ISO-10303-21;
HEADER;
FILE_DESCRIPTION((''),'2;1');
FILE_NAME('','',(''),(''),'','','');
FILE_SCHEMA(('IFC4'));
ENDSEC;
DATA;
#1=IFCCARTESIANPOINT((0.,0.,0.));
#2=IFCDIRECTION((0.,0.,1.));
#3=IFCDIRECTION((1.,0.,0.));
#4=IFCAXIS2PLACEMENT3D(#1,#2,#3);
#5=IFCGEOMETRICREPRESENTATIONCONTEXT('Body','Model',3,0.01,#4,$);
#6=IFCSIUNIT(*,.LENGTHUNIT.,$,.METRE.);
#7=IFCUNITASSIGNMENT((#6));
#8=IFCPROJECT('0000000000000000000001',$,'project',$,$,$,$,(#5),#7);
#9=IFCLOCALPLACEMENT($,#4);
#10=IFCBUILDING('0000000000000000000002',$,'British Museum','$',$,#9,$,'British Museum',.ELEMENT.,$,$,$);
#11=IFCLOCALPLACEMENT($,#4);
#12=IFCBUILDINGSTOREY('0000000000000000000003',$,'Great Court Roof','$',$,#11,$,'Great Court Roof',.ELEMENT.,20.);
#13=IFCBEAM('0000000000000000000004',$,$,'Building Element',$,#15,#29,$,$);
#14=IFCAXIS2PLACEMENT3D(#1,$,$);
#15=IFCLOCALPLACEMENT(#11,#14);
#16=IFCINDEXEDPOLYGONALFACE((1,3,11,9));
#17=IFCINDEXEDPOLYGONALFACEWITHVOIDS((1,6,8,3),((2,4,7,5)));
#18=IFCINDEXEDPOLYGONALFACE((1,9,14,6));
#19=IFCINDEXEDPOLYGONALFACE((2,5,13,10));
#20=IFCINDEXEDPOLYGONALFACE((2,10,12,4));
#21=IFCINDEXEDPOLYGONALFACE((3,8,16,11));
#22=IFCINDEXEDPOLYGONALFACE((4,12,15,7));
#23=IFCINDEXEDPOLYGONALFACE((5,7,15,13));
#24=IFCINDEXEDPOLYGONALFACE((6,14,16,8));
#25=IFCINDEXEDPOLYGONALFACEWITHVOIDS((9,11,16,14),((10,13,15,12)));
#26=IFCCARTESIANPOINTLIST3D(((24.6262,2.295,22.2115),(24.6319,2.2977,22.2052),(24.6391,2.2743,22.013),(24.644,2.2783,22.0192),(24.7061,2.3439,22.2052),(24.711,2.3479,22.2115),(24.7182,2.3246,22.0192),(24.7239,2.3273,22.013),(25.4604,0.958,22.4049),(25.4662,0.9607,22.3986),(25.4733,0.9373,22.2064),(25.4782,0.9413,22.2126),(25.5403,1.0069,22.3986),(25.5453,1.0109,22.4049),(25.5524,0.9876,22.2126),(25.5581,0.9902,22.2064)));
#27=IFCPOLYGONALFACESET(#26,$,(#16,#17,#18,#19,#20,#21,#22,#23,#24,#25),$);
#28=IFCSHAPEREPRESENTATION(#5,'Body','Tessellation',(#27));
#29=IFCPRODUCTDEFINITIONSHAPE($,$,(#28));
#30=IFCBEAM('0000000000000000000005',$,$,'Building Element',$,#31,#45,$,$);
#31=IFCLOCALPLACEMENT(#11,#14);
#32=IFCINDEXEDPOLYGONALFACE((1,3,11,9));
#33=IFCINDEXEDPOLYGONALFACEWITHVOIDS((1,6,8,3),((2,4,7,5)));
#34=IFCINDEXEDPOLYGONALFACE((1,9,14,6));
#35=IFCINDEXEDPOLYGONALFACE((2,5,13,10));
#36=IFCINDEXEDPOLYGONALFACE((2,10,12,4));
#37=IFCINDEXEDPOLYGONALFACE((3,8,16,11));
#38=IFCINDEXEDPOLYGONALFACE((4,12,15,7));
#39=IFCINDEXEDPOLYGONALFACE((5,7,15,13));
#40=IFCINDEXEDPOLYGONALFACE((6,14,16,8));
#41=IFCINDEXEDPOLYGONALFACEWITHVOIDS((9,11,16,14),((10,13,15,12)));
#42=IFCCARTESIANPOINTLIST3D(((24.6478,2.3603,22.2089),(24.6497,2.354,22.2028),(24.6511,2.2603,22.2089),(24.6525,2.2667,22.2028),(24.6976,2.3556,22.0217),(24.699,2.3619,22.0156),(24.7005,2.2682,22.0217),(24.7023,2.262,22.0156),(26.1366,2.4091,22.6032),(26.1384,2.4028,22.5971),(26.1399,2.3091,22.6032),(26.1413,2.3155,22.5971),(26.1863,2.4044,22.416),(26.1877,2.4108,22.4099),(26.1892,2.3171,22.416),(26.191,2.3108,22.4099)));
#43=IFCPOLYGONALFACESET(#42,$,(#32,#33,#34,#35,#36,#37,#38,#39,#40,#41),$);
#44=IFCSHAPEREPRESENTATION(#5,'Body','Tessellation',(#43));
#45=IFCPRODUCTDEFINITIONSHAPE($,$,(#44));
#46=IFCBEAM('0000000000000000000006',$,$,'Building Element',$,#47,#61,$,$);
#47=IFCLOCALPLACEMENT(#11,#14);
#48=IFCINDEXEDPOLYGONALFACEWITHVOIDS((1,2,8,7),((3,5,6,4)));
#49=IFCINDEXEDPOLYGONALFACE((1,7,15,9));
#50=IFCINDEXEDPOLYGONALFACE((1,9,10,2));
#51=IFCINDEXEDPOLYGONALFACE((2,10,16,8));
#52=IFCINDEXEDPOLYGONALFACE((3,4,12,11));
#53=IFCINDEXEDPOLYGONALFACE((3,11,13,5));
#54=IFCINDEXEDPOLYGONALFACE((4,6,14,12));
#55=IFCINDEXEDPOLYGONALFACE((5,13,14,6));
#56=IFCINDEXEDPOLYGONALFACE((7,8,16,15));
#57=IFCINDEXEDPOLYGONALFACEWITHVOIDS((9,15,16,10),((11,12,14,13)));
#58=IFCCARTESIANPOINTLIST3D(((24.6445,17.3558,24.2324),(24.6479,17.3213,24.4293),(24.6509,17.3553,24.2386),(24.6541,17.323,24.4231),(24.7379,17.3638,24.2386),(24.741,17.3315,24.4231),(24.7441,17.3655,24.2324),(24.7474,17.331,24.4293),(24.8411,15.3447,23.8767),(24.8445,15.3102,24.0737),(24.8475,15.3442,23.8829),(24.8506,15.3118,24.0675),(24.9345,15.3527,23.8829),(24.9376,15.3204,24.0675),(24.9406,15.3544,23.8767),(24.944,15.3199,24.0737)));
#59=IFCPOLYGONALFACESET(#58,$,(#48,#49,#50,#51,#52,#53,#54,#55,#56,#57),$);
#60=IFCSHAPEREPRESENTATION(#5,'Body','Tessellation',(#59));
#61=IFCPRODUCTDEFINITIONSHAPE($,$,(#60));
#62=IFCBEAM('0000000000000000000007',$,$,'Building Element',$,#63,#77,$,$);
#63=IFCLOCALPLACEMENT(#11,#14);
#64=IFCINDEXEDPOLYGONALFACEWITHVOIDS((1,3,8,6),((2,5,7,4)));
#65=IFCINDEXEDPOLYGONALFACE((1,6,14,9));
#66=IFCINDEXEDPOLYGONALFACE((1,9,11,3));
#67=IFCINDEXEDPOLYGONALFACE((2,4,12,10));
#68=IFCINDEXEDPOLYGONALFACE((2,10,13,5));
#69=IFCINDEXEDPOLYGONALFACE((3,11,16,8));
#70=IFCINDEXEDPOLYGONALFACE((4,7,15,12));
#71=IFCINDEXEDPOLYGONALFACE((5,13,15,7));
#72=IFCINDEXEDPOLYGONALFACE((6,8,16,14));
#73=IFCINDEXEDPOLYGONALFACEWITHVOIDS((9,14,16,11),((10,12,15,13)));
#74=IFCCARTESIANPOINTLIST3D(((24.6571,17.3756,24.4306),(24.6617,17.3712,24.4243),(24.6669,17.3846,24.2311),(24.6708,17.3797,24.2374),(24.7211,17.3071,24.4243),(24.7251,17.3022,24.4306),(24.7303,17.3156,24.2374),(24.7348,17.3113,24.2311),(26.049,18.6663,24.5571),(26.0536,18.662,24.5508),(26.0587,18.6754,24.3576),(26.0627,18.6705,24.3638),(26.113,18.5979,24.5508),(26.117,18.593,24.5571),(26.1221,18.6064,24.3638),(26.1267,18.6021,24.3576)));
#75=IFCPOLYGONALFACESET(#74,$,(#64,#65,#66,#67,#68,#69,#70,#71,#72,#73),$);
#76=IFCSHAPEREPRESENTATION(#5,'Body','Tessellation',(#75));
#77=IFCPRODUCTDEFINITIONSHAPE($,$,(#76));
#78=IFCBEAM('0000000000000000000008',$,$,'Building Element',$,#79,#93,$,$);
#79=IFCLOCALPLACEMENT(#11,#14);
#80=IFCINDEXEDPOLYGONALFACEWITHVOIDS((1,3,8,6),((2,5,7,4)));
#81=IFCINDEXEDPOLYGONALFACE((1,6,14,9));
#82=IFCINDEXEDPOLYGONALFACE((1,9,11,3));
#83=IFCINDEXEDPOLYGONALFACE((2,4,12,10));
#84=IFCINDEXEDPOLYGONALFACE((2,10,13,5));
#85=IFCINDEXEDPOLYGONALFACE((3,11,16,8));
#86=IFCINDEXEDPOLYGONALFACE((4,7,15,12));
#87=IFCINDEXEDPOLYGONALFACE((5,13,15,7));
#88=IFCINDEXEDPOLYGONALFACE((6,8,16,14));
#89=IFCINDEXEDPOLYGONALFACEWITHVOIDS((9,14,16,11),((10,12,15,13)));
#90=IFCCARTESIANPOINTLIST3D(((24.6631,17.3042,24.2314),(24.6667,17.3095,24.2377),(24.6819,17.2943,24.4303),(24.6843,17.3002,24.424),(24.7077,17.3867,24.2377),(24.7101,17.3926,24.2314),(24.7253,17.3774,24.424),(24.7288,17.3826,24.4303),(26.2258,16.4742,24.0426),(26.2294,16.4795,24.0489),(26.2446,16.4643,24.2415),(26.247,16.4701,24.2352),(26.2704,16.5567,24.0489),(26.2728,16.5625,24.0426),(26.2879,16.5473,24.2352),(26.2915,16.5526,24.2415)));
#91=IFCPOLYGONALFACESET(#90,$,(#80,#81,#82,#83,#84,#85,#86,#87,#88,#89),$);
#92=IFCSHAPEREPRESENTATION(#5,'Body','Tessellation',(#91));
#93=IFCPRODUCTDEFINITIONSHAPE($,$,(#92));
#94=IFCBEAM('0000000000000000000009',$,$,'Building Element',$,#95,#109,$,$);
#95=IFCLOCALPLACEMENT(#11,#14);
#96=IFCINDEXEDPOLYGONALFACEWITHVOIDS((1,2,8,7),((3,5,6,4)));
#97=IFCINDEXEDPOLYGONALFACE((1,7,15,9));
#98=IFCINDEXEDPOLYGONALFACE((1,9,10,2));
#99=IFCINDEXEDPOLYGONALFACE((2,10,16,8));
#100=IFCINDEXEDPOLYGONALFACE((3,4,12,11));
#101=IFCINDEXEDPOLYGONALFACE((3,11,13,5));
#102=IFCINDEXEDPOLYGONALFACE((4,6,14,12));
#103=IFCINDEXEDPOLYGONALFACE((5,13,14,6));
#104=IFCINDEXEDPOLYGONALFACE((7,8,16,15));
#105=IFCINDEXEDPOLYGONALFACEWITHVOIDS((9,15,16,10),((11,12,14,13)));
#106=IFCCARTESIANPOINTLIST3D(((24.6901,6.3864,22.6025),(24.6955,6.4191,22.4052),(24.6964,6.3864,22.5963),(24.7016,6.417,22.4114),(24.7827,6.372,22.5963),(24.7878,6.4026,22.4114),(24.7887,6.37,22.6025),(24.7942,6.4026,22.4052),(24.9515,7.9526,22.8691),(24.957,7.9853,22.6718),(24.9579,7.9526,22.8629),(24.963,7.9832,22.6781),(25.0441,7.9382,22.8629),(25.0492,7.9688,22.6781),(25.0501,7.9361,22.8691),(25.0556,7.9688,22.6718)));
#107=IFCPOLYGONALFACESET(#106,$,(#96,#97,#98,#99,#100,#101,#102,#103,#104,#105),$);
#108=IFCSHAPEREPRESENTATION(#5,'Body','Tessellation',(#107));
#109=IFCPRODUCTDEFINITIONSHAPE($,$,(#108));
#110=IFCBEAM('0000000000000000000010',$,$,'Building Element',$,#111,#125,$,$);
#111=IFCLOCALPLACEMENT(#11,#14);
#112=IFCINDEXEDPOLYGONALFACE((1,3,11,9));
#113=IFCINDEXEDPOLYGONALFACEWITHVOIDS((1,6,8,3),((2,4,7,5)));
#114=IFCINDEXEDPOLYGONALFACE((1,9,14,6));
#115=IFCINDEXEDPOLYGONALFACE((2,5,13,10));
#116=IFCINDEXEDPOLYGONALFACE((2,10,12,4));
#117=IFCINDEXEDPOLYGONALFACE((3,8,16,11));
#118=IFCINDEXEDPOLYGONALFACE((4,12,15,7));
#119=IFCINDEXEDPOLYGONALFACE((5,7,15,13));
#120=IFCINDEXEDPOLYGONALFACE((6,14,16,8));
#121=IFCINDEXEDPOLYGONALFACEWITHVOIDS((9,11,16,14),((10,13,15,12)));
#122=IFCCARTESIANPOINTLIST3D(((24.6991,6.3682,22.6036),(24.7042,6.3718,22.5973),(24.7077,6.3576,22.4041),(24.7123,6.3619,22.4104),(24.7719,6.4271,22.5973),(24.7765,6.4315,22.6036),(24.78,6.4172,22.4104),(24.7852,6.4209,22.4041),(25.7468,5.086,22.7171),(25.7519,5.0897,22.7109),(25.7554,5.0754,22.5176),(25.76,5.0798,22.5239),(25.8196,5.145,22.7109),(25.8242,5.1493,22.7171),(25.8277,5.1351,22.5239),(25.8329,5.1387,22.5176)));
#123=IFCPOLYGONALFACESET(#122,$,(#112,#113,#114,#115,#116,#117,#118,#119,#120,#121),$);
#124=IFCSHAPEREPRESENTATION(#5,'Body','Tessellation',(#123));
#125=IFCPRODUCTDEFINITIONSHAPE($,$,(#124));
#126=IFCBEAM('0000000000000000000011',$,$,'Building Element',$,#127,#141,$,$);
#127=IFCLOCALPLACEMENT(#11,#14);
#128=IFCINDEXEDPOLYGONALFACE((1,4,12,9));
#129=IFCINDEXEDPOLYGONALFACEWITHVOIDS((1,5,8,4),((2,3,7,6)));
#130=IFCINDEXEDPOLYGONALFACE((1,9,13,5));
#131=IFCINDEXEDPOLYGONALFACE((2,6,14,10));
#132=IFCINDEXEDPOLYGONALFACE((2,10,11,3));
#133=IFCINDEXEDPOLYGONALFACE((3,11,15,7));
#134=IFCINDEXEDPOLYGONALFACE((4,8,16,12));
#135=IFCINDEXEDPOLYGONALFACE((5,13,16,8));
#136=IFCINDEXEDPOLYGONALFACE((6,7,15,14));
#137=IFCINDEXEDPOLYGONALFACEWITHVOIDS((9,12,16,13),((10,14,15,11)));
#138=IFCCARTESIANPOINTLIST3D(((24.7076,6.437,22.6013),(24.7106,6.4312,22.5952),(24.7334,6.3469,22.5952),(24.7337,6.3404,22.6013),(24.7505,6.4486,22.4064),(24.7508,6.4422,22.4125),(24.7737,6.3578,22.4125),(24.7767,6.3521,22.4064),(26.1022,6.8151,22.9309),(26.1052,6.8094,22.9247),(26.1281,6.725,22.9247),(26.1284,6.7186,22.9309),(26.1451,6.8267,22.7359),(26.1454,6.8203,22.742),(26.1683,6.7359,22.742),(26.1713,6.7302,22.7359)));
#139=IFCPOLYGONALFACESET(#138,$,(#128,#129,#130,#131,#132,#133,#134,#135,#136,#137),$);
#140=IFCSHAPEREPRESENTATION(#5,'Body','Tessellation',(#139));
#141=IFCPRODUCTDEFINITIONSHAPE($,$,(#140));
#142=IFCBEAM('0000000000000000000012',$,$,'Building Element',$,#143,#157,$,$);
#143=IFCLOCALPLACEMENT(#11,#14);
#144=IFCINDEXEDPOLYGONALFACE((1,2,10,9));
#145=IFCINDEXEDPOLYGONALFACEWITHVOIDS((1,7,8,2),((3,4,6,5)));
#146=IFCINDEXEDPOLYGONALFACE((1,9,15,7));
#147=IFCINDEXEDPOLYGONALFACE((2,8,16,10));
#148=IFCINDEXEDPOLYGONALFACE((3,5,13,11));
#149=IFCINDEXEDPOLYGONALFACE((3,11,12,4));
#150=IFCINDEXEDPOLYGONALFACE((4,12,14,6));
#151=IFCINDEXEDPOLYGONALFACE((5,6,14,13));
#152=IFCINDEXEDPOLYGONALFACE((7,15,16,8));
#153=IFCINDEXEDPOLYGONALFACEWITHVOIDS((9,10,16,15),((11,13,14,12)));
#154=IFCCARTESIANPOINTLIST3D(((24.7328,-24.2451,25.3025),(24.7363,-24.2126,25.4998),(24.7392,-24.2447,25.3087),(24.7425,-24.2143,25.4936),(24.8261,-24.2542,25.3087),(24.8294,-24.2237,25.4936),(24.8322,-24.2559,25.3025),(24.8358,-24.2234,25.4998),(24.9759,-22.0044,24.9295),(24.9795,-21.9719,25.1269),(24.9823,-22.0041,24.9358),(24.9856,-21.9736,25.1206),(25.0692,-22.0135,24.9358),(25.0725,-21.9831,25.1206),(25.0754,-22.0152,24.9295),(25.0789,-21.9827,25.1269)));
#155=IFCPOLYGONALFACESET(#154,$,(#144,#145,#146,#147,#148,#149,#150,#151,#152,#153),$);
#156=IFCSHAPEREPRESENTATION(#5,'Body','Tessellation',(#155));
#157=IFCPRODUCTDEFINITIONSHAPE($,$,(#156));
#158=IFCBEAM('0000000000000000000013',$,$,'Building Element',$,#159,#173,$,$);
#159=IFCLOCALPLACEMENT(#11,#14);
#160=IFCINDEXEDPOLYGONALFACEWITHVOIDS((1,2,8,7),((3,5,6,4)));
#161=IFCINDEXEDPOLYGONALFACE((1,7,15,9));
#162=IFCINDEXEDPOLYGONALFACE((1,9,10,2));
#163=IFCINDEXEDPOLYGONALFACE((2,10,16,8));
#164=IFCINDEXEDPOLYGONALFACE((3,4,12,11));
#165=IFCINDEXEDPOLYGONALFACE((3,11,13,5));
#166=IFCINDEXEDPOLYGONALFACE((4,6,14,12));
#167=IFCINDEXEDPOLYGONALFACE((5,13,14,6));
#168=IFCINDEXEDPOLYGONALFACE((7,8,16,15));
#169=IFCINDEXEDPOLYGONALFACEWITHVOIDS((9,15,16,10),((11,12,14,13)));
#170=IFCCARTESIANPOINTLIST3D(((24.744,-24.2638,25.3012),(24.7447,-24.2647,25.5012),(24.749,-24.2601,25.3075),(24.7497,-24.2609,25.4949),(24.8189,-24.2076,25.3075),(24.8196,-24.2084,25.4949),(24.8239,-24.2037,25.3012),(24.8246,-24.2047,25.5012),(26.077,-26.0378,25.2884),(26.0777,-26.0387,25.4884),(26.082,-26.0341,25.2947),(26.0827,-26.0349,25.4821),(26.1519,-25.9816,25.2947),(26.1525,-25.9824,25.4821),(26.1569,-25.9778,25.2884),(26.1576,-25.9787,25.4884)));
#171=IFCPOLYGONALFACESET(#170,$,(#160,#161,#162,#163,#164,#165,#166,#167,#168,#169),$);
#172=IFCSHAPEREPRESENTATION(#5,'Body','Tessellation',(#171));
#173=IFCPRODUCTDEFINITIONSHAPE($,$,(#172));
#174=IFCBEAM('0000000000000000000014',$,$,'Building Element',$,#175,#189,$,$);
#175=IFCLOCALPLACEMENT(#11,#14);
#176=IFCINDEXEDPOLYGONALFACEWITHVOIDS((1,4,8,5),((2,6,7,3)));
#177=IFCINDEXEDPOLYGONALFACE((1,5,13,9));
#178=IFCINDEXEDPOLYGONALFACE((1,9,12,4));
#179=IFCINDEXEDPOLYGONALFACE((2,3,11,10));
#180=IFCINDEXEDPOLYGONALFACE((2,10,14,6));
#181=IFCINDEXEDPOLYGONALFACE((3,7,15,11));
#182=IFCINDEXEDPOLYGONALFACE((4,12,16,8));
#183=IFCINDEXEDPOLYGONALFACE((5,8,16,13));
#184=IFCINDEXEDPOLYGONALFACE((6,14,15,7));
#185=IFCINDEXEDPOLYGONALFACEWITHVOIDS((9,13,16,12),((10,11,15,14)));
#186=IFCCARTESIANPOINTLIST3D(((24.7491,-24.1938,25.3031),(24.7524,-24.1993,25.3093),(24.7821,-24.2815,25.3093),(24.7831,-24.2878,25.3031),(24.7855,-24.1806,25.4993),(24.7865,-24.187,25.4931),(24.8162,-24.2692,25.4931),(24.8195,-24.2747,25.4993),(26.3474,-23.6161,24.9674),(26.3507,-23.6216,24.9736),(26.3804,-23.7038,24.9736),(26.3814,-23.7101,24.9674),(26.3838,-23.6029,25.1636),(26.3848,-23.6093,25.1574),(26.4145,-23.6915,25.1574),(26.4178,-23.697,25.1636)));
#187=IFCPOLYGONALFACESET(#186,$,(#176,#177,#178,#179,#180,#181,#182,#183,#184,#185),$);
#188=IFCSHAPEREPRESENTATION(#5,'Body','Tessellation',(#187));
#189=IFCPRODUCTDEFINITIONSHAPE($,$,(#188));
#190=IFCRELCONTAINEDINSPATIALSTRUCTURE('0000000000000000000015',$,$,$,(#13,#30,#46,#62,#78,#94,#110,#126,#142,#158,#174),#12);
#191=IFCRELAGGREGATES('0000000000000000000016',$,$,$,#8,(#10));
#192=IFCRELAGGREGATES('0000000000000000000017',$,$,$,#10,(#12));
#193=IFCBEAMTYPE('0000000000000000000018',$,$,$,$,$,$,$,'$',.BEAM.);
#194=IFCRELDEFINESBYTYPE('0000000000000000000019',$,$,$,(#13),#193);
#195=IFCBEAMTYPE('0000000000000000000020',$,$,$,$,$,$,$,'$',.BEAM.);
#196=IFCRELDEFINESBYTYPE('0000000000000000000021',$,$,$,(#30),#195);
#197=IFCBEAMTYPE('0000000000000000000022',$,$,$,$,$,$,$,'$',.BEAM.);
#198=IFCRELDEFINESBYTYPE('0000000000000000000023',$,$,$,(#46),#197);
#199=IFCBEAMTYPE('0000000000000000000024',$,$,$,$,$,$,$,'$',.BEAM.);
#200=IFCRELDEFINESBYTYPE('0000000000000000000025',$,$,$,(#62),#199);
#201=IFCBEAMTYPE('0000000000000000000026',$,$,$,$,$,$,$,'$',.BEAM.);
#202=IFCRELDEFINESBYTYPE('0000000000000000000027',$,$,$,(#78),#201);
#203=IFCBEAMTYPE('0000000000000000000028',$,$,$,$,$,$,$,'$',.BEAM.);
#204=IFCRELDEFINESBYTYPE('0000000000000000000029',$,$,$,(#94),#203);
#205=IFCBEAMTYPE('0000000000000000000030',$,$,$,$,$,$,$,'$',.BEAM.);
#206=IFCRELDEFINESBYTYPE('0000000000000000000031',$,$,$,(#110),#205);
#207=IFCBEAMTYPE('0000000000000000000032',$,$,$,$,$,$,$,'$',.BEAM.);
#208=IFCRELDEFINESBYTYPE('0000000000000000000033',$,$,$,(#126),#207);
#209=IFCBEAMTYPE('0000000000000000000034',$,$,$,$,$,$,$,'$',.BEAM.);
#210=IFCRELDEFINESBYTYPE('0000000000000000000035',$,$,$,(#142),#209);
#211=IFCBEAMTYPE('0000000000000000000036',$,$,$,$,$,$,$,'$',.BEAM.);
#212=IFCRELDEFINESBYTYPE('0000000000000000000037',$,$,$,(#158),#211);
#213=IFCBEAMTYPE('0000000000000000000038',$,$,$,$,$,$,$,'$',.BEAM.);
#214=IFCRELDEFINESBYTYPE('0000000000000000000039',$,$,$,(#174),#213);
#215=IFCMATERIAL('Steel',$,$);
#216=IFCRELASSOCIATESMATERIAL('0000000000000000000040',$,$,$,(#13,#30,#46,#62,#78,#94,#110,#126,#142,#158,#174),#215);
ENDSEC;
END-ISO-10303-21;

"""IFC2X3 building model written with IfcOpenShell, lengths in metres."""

from ifc_helpers import new_model, si_unit, frame, origin_with_axes, origin_2d, place, context, project, spatial, hollow_rectangle, extrude, material, type_object, element, save


model = new_model("IFC2X3")

# Units and contexts
model_context = context("Model", 3, precision=0.01, world=origin_with_axes(), identifier="Body")
ifc_project = project(units=[si_unit("LENGTHUNIT", "METRE")], contexts=[model_context])

# Building, storey
building_placement = place(None, origin_with_axes())
building = spatial("IfcBuilding", under=ifc_project, at=building_placement, Name="British Museum", Description="$", LongName="British Museum", CompositionType="ELEMENT")
storey_placement = place(None, origin_with_axes())
storey = spatial("IfcBuildingStorey", under=building, at=storey_placement, Name="Great Court Roof", Description="$", LongName="Great Court Roof", CompositionType="ELEMENT", Elevation=20.0)

# Beams
ifc_material = material(Name="Steel")
beam_type_1 = type_object("IfcBeamType", ElementType="$", PredefinedType="BEAM")
beam_1_placement = place(None, origin_with_axes())
element("IfcBeam", 1, at=beam_1_placement, inside=storey, type_object=beam_type_1, material=ifc_material, Description="Building Element", context=model_context, shape_type="SweptSolid", body=[
    extrude(hollow_rectangle(XDim=0.1, YDim=0.2, WallThickness=0.0063, InnerFilletRadius=-0.0063, OuterFilletRadius=0.0, at=origin_2d()), frame((24.6751, 2.3111, 22.1122), z_axis=(0.525414, -0.842083, 0.121807), x_axis=(0.8484, 0.529356, 0.0)), (0.0, 0.0, 1.0), 1.5878),
])
beam_type_2 = type_object("IfcBeamType", ElementType="$", PredefinedType="BEAM")
beam_2_placement = place(None, origin_with_axes())
element("IfcBeam", 2, at=beam_2_placement, inside=storey, type_object=beam_type_2, material=ifc_material, Description="Building Element", context=model_context, shape_type="SweptSolid", body=[
    extrude(hollow_rectangle(XDim=0.1, YDim=0.2, WallThickness=0.0063, InnerFilletRadius=-0.0063, OuterFilletRadius=0.0, at=origin_2d()), frame((24.6751, 2.3111, 22.1122), z_axis=(0.966181, 0.031687, 0.255909), x_axis=(-0.032778, 0.999463, 0.0)), (0.0, 0.0, 1.0), 1.5409),
])
beam_type_3 = type_object("IfcBeamType", ElementType="$", PredefinedType="BEAM")
beam_3_placement = place(None, origin_with_axes())
element("IfcBeam", 3, at=beam_3_placement, inside=storey, type_object=beam_type_3, material=ifc_material, Description="Building Element", context=model_context, shape_type="SweptSolid", body=[
    extrude(hollow_rectangle(XDim=0.1, YDim=0.2, WallThickness=0.0063, InnerFilletRadius=-0.0063, OuterFilletRadius=0.0, at=origin_2d()), frame((24.696, 17.3434, 24.3308), z_axis=(0.095802, -0.980195, -0.173321), x_axis=(0.995258, 0.097274, 0.0)), (0.0, 0.0, 1.0), 2.0518),
])
beam_type_4 = type_object("IfcBeamType", ElementType="$", PredefinedType="BEAM")
beam_4_placement = place(None, origin_with_axes())
element("IfcBeam", 4, at=beam_4_placement, inside=storey, type_object=beam_type_4, material=ifc_material, Description="Building Element", context=model_context, shape_type="SweptSolid", body=[
    extrude(hollow_rectangle(XDim=0.1, YDim=0.2, WallThickness=0.0063, InnerFilletRadius=-0.0063, OuterFilletRadius=0.0, at=origin_2d()), frame((24.696, 17.3434, 24.3308), z_axis=(0.731615, 0.678468, 0.066489), x_axis=(-0.679972, 0.733238, 0.0)), (0.0, 0.0, 1.0), 1.9025),
])
beam_type_5 = type_object("IfcBeamType", ElementType="$", PredefinedType="BEAM")
beam_5_placement = place(None, origin_with_axes())
element("IfcBeam", 5, at=beam_5_placement, inside=storey, type_object=beam_type_5, material=ifc_material, Description="Building Element", context=model_context, shape_type="SweptSolid", body=[
    extrude(hollow_rectangle(XDim=0.1, YDim=0.2, WallThickness=0.0063, InnerFilletRadius=-0.0063, OuterFilletRadius=0.0, at=origin_2d()), frame((24.696, 17.3434, 24.3308), z_axis=(0.878168, -0.466437, -0.106103), x_axis=(0.469085, 0.883153, 0.0)), (0.0, 0.0, 1.0), 1.7795),
])
beam_type_6 = type_object("IfcBeamType", ElementType="$", PredefinedType="BEAM")
beam_6_placement = place(None, origin_with_axes())
element("IfcBeam", 6, at=beam_6_placement, inside=storey, type_object=beam_type_6, material=ifc_material, Description="Building Element", context=model_context, shape_type="SweptSolid", body=[
    extrude(hollow_rectangle(XDim=0.1, YDim=0.2, WallThickness=0.0063, InnerFilletRadius=-0.0063, OuterFilletRadius=0.0, at=origin_2d()), frame((24.7421, 6.3945, 22.5038), z_axis=(0.162377, 0.972734, 0.165594), x_axis=(-0.986352, 0.16465, 0.0)), (0.0, 0.0, 1.0), 1.6101),
])
beam_type_7 = type_object("IfcBeamType", ElementType="$", PredefinedType="BEAM")
beam_7_placement = place(None, origin_with_axes())
element("IfcBeam", 7, at=beam_7_placement, inside=storey, type_object=beam_type_7, material=ifc_material, Description="Building Element", context=model_context, shape_type="SweptSolid", body=[
    extrude(hollow_rectangle(XDim=0.1, YDim=0.2, WallThickness=0.0063, InnerFilletRadius=-0.0063, OuterFilletRadius=0.0, at=origin_2d()), frame((24.7421, 6.3945, 22.5038), z_axis=(0.631284, -0.772529, 0.06841), x_axis=(0.774343, 0.632766, 0.0)), (0.0, 0.0, 1.0), 1.6597),
])
beam_type_8 = type_object("IfcBeamType", ElementType="$", PredefinedType="BEAM")
beam_8_placement = place(None, origin_with_axes())
element("IfcBeam", 8, at=beam_8_placement, inside=storey, type_object=beam_type_8, material=ifc_material, Description="Building Element", context=model_context, shape_type="SweptSolid", body=[
    extrude(hollow_rectangle(XDim=0.1, YDim=0.2, WallThickness=0.0063, InnerFilletRadius=-0.0063, OuterFilletRadius=0.0, at=origin_2d()), frame((24.7421, 6.3945, 22.5038), z_axis=(0.940997, 0.255123, 0.222346), x_axis=(-0.261673, 0.965157, 0.0)), (0.0, 0.0, 1.0), 1.4821),
])
beam_type_9 = type_object("IfcBeamType", ElementType="$", PredefinedType="BEAM")
beam_9_placement = place(None, origin_with_axes())
element("IfcBeam", 9, at=beam_9_placement, inside=storey, type_object=beam_type_9, material=ifc_material, Description="Building Element", context=model_context, shape_type="SweptSolid", body=[
    extrude(hollow_rectangle(XDim=0.1, YDim=0.2, WallThickness=0.0063, InnerFilletRadius=-0.0063, OuterFilletRadius=0.0, at=origin_2d()), frame((24.7843, -24.2342, 25.4012), z_axis=(0.106422, 0.980824, -0.163272), x_axis=(-0.994165, 0.10787, 0.0)), (0.0, 0.0, 1.0), 2.2845),
])
beam_type_10 = type_object("IfcBeamType", ElementType="$", PredefinedType="BEAM")
beam_10_placement = place(None, origin_with_axes())
element("IfcBeam", 10, at=beam_10_placement, inside=storey, type_object=beam_type_10, material=ifc_material, Description="Building Element", context=model_context, shape_type="SweptSolid", body=[
    extrude(hollow_rectangle(XDim=0.1, YDim=0.2, WallThickness=0.0063, InnerFilletRadius=-0.0063, OuterFilletRadius=0.0, at=origin_2d()), frame((24.7843, -24.2342, 25.4012), z_axis=(0.600704, -0.799451, -0.005747), x_axis=(0.799464, 0.600714, 0.0)), (0.0, 0.0, 1.0), 2.219),
])
beam_type_11 = type_object("IfcBeamType", ElementType="$", PredefinedType="BEAM")
beam_11_placement = place(None, origin_with_axes())
element("IfcBeam", 11, at=beam_11_placement, inside=storey, type_object=beam_type_11, material=ifc_material, Description="Building Element", context=model_context, shape_type="SweptSolid", body=[
    extrude(hollow_rectangle(XDim=0.1, YDim=0.2, WallThickness=0.0063, InnerFilletRadius=-0.0063, OuterFilletRadius=0.0, at=origin_2d()), frame((24.7843, -24.2342, 25.4012), z_axis=(0.922628, 0.333479, -0.193776), x_axis=(-0.339922, 0.940454, 0.0)), (0.0, 0.0, 1.0), 1.7324),
])

save(model, "model.ifc")
